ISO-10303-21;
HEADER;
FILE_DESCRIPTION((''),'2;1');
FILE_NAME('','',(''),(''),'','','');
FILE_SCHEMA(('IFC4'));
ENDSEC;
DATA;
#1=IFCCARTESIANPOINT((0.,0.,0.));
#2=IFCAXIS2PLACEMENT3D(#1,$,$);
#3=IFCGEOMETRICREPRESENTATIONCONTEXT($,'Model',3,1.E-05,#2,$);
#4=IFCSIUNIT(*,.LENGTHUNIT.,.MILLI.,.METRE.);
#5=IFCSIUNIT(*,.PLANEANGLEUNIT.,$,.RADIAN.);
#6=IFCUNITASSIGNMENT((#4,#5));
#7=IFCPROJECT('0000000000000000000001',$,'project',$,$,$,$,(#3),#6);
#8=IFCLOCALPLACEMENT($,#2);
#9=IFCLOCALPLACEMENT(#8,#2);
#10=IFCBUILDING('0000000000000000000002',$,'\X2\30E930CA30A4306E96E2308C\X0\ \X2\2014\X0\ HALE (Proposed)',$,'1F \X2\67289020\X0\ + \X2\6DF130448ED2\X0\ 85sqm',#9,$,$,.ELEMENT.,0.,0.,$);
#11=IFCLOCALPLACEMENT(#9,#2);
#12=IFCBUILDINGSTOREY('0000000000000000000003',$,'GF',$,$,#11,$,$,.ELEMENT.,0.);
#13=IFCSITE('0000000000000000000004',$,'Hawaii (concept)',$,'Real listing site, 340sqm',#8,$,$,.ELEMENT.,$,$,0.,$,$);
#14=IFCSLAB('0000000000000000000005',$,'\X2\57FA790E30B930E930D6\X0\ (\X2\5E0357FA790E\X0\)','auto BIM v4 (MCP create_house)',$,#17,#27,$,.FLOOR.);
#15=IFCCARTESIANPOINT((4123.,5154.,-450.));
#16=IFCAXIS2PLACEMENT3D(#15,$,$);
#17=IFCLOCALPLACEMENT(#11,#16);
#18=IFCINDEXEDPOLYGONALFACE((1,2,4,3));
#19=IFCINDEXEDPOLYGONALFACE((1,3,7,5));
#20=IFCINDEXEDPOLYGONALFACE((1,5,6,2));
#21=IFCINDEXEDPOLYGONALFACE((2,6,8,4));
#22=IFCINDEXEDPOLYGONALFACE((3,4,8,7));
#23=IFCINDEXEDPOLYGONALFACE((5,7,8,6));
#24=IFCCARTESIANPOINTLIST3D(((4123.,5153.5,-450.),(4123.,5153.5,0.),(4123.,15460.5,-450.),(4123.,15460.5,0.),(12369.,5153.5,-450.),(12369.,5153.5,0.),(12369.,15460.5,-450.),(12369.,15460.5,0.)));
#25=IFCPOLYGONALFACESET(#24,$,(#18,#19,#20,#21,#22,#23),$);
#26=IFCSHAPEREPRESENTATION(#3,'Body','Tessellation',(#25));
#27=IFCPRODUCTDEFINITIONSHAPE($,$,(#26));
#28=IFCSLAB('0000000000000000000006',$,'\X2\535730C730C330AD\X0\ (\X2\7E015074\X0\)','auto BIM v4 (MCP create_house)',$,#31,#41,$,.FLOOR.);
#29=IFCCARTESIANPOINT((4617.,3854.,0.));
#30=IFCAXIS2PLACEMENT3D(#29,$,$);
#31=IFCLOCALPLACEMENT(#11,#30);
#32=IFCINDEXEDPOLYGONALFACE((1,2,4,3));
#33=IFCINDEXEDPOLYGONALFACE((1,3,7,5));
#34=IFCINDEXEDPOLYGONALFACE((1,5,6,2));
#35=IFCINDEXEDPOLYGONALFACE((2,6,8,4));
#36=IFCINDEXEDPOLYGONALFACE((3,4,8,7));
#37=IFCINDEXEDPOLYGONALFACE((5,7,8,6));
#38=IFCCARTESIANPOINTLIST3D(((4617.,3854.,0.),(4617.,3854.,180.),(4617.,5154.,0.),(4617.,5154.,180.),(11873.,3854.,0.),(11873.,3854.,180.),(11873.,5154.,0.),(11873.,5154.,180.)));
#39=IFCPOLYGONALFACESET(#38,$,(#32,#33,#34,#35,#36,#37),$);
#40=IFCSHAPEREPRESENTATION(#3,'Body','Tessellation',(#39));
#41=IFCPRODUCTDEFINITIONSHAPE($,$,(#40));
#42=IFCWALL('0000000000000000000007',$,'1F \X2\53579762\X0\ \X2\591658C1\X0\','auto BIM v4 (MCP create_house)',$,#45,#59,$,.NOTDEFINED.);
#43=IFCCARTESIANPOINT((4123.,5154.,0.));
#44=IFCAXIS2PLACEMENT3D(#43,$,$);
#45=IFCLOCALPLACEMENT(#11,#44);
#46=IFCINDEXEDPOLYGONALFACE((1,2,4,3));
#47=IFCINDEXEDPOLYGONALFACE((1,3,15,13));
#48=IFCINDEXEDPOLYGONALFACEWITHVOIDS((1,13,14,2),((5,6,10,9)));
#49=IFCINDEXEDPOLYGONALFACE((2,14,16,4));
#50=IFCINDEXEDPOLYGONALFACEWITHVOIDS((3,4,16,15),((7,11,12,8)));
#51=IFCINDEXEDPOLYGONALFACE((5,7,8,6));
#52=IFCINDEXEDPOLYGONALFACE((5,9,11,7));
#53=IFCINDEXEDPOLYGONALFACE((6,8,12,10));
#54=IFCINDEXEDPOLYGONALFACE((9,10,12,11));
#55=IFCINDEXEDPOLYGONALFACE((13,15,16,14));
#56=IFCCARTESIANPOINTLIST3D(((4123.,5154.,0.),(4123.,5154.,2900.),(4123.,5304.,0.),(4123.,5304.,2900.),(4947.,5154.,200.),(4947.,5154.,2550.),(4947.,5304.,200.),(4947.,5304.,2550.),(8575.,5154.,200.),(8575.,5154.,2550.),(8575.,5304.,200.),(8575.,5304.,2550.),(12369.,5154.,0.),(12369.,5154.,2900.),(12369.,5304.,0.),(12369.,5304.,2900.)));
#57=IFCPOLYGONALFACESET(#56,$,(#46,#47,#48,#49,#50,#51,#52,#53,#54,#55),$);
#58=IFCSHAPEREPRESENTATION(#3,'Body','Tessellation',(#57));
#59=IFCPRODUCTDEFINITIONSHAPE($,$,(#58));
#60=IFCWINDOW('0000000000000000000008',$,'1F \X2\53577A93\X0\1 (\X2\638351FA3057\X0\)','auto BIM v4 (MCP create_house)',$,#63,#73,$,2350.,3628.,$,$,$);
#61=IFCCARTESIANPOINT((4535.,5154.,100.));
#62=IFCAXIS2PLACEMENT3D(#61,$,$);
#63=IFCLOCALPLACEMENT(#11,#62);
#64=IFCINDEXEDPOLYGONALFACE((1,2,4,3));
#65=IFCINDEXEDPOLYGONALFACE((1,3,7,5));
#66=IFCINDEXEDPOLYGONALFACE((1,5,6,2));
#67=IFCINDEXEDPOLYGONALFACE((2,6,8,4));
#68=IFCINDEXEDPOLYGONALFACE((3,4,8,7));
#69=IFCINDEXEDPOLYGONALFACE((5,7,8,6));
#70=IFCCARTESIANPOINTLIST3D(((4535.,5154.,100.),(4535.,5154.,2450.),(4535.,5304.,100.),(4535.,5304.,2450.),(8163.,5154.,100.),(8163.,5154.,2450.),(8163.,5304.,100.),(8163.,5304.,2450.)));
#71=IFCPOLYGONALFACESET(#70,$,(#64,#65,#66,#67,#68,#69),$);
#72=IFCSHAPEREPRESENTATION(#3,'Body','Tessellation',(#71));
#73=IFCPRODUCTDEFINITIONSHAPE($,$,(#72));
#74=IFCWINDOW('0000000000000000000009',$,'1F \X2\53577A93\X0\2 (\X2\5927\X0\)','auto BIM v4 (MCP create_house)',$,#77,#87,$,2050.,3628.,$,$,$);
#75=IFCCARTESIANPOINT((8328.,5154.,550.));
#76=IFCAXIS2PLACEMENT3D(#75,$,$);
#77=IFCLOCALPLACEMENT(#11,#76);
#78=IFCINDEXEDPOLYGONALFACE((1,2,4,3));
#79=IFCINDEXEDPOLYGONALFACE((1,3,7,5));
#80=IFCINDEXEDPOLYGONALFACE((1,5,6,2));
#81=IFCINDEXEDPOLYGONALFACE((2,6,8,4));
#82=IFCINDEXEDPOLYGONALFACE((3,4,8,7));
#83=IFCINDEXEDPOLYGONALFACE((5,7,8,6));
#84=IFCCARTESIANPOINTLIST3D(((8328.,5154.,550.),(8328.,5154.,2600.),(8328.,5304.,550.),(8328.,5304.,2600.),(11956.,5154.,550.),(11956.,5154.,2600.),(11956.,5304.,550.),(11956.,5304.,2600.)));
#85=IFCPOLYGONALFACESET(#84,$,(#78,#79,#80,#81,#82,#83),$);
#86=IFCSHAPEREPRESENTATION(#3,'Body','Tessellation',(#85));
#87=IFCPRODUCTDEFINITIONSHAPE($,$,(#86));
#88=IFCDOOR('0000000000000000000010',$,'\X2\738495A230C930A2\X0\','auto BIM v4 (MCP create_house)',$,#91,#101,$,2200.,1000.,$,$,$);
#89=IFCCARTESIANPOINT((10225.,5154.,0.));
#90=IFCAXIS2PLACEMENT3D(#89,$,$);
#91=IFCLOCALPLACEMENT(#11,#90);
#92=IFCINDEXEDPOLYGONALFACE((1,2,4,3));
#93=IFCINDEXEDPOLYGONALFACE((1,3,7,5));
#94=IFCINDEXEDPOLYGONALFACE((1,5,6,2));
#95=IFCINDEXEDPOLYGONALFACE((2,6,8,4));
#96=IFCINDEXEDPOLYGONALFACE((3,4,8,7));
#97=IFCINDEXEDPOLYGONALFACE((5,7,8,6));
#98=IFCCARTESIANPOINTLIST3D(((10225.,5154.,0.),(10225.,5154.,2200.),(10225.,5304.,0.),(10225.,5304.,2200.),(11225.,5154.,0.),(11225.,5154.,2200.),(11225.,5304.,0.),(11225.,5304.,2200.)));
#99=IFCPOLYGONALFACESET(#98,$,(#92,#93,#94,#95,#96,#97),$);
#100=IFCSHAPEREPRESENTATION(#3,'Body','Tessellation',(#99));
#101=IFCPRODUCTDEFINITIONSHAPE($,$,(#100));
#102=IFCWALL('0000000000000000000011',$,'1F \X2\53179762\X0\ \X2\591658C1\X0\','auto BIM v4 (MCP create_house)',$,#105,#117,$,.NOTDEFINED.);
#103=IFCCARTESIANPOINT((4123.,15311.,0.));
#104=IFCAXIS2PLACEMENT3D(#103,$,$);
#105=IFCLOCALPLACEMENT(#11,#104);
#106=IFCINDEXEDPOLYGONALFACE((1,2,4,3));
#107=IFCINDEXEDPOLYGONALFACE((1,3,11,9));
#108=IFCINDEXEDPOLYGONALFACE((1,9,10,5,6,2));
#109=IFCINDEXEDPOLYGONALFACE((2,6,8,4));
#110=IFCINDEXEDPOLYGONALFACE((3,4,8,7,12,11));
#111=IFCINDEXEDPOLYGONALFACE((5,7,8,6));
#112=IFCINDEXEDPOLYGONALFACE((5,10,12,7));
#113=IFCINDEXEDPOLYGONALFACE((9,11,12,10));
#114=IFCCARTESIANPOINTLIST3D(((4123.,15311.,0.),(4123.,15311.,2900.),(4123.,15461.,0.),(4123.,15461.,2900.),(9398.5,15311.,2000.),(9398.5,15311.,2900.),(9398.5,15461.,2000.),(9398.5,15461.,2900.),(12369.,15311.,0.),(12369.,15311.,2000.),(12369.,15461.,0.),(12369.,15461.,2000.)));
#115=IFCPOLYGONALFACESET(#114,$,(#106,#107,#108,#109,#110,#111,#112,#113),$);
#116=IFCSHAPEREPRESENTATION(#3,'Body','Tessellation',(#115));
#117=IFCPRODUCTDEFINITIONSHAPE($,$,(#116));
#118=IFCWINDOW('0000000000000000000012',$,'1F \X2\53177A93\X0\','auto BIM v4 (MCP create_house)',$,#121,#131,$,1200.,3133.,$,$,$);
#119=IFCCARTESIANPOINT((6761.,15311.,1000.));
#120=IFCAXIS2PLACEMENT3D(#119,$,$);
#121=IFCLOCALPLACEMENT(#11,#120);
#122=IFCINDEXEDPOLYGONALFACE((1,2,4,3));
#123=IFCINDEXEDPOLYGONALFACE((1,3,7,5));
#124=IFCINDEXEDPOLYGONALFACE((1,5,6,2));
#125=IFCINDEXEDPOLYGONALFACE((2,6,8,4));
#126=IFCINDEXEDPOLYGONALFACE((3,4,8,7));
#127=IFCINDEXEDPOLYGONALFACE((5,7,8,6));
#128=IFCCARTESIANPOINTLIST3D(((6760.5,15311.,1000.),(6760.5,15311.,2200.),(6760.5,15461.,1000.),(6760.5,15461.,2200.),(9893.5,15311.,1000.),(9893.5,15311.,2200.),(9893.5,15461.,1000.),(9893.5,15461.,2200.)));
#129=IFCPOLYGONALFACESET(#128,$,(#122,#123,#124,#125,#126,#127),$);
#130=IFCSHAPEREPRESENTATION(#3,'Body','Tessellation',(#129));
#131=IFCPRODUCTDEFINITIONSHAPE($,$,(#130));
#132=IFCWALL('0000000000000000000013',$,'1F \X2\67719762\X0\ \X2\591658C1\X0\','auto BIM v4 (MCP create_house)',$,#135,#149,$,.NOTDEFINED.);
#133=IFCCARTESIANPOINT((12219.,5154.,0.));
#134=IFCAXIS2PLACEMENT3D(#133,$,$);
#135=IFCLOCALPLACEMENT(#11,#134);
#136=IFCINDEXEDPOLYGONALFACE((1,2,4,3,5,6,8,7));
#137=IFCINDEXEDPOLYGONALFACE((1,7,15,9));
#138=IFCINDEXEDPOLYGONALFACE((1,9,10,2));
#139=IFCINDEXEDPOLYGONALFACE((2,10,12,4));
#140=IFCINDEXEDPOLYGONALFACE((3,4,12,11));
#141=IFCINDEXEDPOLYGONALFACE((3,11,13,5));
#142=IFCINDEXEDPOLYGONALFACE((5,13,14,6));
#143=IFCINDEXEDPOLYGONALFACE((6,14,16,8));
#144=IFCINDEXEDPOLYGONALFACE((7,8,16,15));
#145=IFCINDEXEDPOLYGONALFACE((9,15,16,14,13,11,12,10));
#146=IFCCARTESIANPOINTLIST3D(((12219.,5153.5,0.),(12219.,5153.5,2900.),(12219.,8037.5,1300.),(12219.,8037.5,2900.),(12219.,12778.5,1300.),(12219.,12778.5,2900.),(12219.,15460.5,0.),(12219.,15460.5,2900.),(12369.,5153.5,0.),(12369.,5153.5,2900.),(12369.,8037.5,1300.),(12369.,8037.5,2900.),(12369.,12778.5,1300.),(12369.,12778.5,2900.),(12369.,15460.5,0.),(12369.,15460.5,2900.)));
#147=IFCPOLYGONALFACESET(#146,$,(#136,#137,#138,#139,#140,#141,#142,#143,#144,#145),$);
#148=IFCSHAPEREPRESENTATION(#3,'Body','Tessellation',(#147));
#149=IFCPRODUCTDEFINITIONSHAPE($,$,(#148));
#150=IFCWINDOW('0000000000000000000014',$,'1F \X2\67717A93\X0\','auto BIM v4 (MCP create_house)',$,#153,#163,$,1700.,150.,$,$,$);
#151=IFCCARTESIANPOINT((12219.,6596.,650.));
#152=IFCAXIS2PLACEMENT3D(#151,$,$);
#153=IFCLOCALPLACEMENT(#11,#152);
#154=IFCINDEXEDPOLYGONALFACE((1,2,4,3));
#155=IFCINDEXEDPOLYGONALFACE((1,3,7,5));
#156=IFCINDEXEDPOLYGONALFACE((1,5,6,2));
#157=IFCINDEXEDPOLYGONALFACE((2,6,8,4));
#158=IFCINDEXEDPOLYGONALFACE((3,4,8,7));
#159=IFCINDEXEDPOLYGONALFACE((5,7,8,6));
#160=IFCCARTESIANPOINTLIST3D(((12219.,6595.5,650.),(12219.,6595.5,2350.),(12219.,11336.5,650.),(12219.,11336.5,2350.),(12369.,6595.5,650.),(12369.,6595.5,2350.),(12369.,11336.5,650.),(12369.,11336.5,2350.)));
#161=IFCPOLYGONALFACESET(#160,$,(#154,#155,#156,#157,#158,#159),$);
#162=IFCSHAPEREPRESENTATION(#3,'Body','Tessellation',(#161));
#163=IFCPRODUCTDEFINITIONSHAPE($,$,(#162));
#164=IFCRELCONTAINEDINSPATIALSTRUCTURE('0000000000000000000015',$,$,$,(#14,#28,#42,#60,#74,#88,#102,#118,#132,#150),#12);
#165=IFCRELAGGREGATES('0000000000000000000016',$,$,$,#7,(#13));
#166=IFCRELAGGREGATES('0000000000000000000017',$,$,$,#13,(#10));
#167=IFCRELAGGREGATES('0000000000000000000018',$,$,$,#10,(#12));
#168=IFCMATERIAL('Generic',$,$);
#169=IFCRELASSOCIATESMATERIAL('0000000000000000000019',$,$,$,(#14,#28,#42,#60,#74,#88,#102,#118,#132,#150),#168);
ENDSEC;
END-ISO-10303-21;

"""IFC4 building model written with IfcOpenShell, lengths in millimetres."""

from ifc_helpers import new_model, si_unit, frame, frame_2d, origin, place, context, project, spatial, rectangle, extrude, material, element, fill, save


model = new_model("IFC4")

# Units and contexts
model_context = context("Model", 3, precision=1e-05, world=origin())
ifc_project = project(units=[si_unit("LENGTHUNIT", "METRE", prefix="MILLI"), si_unit("PLANEANGLEUNIT", "RADIAN")], contexts=[model_context])

# Site, building, storey
site_placement = place(None, origin())
site = spatial("IfcSite", under=ifc_project, at=site_placement, Name="Hawaii (concept)", ObjectType="Real listing site, 340sqm", CompositionType="ELEMENT", RefElevation=0.0)
building_placement = place(site_placement, origin())
building = spatial("IfcBuilding", under=site, at=building_placement, Name="ラナイの離れ — HALE (Proposed)", ObjectType="1F 木造 + 深い軒 85sqm", CompositionType="ELEMENT", ElevationOfRefHeight=0.0, ElevationOfTerrain=0.0)
storey_placement = place(building_placement, origin())
storey = spatial("IfcBuildingStorey", under=building, at=storey_placement, Name="GF", CompositionType="ELEMENT", Elevation=0.0)

# Slabs
ifc_material = material(Name="Generic")
slab_1_placement = place(storey_placement, frame((4123.0, 5154.0, -450.0)))
element("IfcSlab", 1, at=slab_1_placement, inside=storey, material=ifc_material, Name="基礎スラブ (布基礎)", Description="auto BIM v4 (MCP create_house)", PredefinedType="FLOOR", context=model_context, shape_type="SweptSolid", body=[
    extrude(rectangle(XDim=8246.0, YDim=10307.0, at=frame_2d((4123.0, 5153.0))), frame((4123.0, 5154.0, -450.0)), (0.0, 0.0, 1.0), 450.0),
])
slab_2_placement = place(storey_placement, frame((4617.0, 3854.0, 0.0)))
element("IfcSlab", 2, at=slab_2_placement, inside=storey, material=ifc_material, Name="南デッキ (縁側)", Description="auto BIM v4 (MCP create_house)", PredefinedType="FLOOR", context=model_context, shape_type="SweptSolid", body=[
    extrude(rectangle(XDim=7256.0, YDim=1300.0, at=frame_2d((3628.0, 650.0))), frame((4617.0, 3854.0, 0.0)), (0.0, 0.0, 1.0), 180.0),
])

# Wall, openings, windows, door
wall_1_placement = place(storey_placement, frame((4123.0, 5154.0, 0.0)))
wall_1 = element("IfcWall", 3, at=wall_1_placement, inside=storey, material=ifc_material, Name="1F 南面 外壁", Description="auto BIM v4 (MCP create_house)", PredefinedType="NOTDEFINED", context=model_context, shape_type="SweptSolid", body=[
    extrude(rectangle(XDim=8246.0, YDim=150.0, at=frame_2d((4123.0, 75.0))), frame((4123.0, 5154.0, 0.0)), (0.0, 0.0, 1.0), 2900.0),
])
opening_1_placement = place(storey_placement, frame((4535.0, 5154.0, 100.0)))
opening_1 = element("IfcOpeningElement", 4, at=opening_1_placement, cuts=wall_1, PredefinedType="NOTDEFINED", context=model_context, shape_type="SweptSolid", body=[
    extrude(rectangle(XDim=3628.0, YDim=150.0, at=frame_2d((1814.0, 75.0))), frame((4535.0, 5154.0, 100.0)), (0.0, 0.0, 1.0), 2350.0),
])
opening_2_placement = place(storey_placement, frame((8328.0, 5154.0, 550.0)))
opening_2 = element("IfcOpeningElement", 5, at=opening_2_placement, cuts=wall_1, PredefinedType="NOTDEFINED", context=model_context, shape_type="SweptSolid", body=[
    extrude(rectangle(XDim=3628.0, YDim=150.0, at=frame_2d((1814.0, 75.0))), frame((8328.0, 5154.0, 550.0)), (0.0, 0.0, 1.0), 2050.0),
])
opening_3_placement = place(storey_placement, frame((10225.0, 5154.0, 0.0)))
opening_3 = element("IfcOpeningElement", 6, at=opening_3_placement, cuts=wall_1, PredefinedType="NOTDEFINED", context=model_context, shape_type="SweptSolid", body=[
    extrude(rectangle(XDim=1000.0, YDim=150.0, at=frame_2d((500.0, 75.0))), frame((10225.0, 5154.0, 0.0)), (0.0, 0.0, 1.0), 2200.0),
])
window_1_placement = place(storey_placement, frame((4535.0, 5154.0, 100.0)))
window_1 = element("IfcWindow", 7, at=window_1_placement, inside=storey, material=ifc_material, Name="1F 南窓1 (掃出し)", Description="auto BIM v4 (MCP create_house)", OverallHeight=2350.0, OverallWidth=3628.0, context=model_context, shape_type="SweptSolid", body=[
    extrude(rectangle(XDim=3628.0, YDim=150.0, at=frame_2d((1814.0, 75.0))), frame((4535.0, 5154.0, 100.0)), (0.0, 0.0, 1.0), 2350.0),
])
fill(opening_1, window_1)
window_2_placement = place(storey_placement, frame((8328.0, 5154.0, 550.0)))
window_2 = element("IfcWindow", 8, at=window_2_placement, inside=storey, material=ifc_material, Name="1F 南窓2 (大)", Description="auto BIM v4 (MCP create_house)", OverallHeight=2050.0, OverallWidth=3628.0, context=model_context, shape_type="SweptSolid", body=[
    extrude(rectangle(XDim=3628.0, YDim=150.0, at=frame_2d((1814.0, 75.0))), frame((8328.0, 5154.0, 550.0)), (0.0, 0.0, 1.0), 2050.0),
])
fill(opening_2, window_2)
door_placement = place(storey_placement, frame((10225.0, 5154.0, 0.0)))
door = element("IfcDoor", 9, at=door_placement, inside=storey, material=ifc_material, Name="玄関ドア", Description="auto BIM v4 (MCP create_house)", OverallHeight=2200.0, OverallWidth=1000.0, context=model_context, shape_type="SweptSolid", body=[
    extrude(rectangle(XDim=1000.0, YDim=150.0, at=frame_2d((500.0, 75.0))), frame((10225.0, 5154.0, 0.0)), (0.0, 0.0, 1.0), 2200.0),
])
fill(opening_3, door)

# Walls, openings, windows
wall_2_placement = place(storey_placement, frame((4123.0, 15311.0, 0.0)))
wall_2 = element("IfcWall", 10, at=wall_2_placement, inside=storey, material=ifc_material, Name="1F 北面 外壁", Description="auto BIM v4 (MCP create_house)", PredefinedType="NOTDEFINED", context=model_context, shape_type="SweptSolid", body=[
    extrude(rectangle(XDim=8246.0, YDim=150.0, at=frame_2d((4123.0, 75.0))), frame((4123.0, 15311.0, 0.0)), (0.0, 0.0, 1.0), 2900.0),
])
opening_4_placement = place(storey_placement, frame((6761.0, 15311.0, 1000.0)))
opening_4 = element("IfcOpeningElement", 11, at=opening_4_placement, cuts=wall_2, PredefinedType="NOTDEFINED", context=model_context, shape_type="SweptSolid", body=[
    extrude(rectangle(XDim=3133.0, YDim=150.0, at=frame_2d((1566.0, 75.0))), frame((6761.0, 15311.0, 1000.0)), (0.0, 0.0, 1.0), 1200.0),
])
window_3_placement = place(storey_placement, frame((6761.0, 15311.0, 1000.0)))
window_3 = element("IfcWindow", 12, at=window_3_placement, inside=storey, material=ifc_material, Name="1F 北窓", Description="auto BIM v4 (MCP create_house)", OverallHeight=1200.0, OverallWidth=3133.0, context=model_context, shape_type="SweptSolid", body=[
    extrude(rectangle(XDim=3133.0, YDim=150.0, at=frame_2d((1566.0, 75.0))), frame((6761.0, 15311.0, 1000.0)), (0.0, 0.0, 1.0), 1200.0),
])
fill(opening_4, window_3)
wall_3_placement = place(storey_placement, frame((12219.0, 5154.0, 0.0)))
wall_3 = element("IfcWall", 13, at=wall_3_placement, inside=storey, material=ifc_material, Name="1F 東面 外壁", Description="auto BIM v4 (MCP create_house)", PredefinedType="NOTDEFINED", context=model_context, shape_type="SweptSolid", body=[
    extrude(rectangle(XDim=150.0, YDim=10307.0, at=frame_2d((75.0, 5153.0))), frame((12219.0, 5154.0, 0.0)), (0.0, 0.0, 1.0), 2900.0),
])
opening_5_placement = place(storey_placement, frame((12219.0, 6596.0, 650.0)))
opening_5 = element("IfcOpeningElement", 14, at=opening_5_placement, cuts=wall_3, PredefinedType="NOTDEFINED", context=model_context, shape_type="SweptSolid", body=[
    extrude(rectangle(XDim=150.0, YDim=4741.0, at=frame_2d((75.0, 2370.0))), frame((12219.0, 6596.0, 650.0)), (0.0, 0.0, 1.0), 1700.0),
])
window_4_placement = place(storey_placement, frame((12219.0, 6596.0, 650.0)))
window_4 = element("IfcWindow", 15, at=window_4_placement, inside=storey, material=ifc_material, Name="1F 東窓", Description="auto BIM v4 (MCP create_house)", OverallHeight=1700.0, OverallWidth=150.0, context=model_context, shape_type="SweptSolid", body=[
    extrude(rectangle(XDim=150.0, YDim=4741.0, at=frame_2d((75.0, 2370.0))), frame((12219.0, 6596.0, 650.0)), (0.0, 0.0, 1.0), 1700.0),
])
fill(opening_5, window_4)

save(model, "model.ifc")
